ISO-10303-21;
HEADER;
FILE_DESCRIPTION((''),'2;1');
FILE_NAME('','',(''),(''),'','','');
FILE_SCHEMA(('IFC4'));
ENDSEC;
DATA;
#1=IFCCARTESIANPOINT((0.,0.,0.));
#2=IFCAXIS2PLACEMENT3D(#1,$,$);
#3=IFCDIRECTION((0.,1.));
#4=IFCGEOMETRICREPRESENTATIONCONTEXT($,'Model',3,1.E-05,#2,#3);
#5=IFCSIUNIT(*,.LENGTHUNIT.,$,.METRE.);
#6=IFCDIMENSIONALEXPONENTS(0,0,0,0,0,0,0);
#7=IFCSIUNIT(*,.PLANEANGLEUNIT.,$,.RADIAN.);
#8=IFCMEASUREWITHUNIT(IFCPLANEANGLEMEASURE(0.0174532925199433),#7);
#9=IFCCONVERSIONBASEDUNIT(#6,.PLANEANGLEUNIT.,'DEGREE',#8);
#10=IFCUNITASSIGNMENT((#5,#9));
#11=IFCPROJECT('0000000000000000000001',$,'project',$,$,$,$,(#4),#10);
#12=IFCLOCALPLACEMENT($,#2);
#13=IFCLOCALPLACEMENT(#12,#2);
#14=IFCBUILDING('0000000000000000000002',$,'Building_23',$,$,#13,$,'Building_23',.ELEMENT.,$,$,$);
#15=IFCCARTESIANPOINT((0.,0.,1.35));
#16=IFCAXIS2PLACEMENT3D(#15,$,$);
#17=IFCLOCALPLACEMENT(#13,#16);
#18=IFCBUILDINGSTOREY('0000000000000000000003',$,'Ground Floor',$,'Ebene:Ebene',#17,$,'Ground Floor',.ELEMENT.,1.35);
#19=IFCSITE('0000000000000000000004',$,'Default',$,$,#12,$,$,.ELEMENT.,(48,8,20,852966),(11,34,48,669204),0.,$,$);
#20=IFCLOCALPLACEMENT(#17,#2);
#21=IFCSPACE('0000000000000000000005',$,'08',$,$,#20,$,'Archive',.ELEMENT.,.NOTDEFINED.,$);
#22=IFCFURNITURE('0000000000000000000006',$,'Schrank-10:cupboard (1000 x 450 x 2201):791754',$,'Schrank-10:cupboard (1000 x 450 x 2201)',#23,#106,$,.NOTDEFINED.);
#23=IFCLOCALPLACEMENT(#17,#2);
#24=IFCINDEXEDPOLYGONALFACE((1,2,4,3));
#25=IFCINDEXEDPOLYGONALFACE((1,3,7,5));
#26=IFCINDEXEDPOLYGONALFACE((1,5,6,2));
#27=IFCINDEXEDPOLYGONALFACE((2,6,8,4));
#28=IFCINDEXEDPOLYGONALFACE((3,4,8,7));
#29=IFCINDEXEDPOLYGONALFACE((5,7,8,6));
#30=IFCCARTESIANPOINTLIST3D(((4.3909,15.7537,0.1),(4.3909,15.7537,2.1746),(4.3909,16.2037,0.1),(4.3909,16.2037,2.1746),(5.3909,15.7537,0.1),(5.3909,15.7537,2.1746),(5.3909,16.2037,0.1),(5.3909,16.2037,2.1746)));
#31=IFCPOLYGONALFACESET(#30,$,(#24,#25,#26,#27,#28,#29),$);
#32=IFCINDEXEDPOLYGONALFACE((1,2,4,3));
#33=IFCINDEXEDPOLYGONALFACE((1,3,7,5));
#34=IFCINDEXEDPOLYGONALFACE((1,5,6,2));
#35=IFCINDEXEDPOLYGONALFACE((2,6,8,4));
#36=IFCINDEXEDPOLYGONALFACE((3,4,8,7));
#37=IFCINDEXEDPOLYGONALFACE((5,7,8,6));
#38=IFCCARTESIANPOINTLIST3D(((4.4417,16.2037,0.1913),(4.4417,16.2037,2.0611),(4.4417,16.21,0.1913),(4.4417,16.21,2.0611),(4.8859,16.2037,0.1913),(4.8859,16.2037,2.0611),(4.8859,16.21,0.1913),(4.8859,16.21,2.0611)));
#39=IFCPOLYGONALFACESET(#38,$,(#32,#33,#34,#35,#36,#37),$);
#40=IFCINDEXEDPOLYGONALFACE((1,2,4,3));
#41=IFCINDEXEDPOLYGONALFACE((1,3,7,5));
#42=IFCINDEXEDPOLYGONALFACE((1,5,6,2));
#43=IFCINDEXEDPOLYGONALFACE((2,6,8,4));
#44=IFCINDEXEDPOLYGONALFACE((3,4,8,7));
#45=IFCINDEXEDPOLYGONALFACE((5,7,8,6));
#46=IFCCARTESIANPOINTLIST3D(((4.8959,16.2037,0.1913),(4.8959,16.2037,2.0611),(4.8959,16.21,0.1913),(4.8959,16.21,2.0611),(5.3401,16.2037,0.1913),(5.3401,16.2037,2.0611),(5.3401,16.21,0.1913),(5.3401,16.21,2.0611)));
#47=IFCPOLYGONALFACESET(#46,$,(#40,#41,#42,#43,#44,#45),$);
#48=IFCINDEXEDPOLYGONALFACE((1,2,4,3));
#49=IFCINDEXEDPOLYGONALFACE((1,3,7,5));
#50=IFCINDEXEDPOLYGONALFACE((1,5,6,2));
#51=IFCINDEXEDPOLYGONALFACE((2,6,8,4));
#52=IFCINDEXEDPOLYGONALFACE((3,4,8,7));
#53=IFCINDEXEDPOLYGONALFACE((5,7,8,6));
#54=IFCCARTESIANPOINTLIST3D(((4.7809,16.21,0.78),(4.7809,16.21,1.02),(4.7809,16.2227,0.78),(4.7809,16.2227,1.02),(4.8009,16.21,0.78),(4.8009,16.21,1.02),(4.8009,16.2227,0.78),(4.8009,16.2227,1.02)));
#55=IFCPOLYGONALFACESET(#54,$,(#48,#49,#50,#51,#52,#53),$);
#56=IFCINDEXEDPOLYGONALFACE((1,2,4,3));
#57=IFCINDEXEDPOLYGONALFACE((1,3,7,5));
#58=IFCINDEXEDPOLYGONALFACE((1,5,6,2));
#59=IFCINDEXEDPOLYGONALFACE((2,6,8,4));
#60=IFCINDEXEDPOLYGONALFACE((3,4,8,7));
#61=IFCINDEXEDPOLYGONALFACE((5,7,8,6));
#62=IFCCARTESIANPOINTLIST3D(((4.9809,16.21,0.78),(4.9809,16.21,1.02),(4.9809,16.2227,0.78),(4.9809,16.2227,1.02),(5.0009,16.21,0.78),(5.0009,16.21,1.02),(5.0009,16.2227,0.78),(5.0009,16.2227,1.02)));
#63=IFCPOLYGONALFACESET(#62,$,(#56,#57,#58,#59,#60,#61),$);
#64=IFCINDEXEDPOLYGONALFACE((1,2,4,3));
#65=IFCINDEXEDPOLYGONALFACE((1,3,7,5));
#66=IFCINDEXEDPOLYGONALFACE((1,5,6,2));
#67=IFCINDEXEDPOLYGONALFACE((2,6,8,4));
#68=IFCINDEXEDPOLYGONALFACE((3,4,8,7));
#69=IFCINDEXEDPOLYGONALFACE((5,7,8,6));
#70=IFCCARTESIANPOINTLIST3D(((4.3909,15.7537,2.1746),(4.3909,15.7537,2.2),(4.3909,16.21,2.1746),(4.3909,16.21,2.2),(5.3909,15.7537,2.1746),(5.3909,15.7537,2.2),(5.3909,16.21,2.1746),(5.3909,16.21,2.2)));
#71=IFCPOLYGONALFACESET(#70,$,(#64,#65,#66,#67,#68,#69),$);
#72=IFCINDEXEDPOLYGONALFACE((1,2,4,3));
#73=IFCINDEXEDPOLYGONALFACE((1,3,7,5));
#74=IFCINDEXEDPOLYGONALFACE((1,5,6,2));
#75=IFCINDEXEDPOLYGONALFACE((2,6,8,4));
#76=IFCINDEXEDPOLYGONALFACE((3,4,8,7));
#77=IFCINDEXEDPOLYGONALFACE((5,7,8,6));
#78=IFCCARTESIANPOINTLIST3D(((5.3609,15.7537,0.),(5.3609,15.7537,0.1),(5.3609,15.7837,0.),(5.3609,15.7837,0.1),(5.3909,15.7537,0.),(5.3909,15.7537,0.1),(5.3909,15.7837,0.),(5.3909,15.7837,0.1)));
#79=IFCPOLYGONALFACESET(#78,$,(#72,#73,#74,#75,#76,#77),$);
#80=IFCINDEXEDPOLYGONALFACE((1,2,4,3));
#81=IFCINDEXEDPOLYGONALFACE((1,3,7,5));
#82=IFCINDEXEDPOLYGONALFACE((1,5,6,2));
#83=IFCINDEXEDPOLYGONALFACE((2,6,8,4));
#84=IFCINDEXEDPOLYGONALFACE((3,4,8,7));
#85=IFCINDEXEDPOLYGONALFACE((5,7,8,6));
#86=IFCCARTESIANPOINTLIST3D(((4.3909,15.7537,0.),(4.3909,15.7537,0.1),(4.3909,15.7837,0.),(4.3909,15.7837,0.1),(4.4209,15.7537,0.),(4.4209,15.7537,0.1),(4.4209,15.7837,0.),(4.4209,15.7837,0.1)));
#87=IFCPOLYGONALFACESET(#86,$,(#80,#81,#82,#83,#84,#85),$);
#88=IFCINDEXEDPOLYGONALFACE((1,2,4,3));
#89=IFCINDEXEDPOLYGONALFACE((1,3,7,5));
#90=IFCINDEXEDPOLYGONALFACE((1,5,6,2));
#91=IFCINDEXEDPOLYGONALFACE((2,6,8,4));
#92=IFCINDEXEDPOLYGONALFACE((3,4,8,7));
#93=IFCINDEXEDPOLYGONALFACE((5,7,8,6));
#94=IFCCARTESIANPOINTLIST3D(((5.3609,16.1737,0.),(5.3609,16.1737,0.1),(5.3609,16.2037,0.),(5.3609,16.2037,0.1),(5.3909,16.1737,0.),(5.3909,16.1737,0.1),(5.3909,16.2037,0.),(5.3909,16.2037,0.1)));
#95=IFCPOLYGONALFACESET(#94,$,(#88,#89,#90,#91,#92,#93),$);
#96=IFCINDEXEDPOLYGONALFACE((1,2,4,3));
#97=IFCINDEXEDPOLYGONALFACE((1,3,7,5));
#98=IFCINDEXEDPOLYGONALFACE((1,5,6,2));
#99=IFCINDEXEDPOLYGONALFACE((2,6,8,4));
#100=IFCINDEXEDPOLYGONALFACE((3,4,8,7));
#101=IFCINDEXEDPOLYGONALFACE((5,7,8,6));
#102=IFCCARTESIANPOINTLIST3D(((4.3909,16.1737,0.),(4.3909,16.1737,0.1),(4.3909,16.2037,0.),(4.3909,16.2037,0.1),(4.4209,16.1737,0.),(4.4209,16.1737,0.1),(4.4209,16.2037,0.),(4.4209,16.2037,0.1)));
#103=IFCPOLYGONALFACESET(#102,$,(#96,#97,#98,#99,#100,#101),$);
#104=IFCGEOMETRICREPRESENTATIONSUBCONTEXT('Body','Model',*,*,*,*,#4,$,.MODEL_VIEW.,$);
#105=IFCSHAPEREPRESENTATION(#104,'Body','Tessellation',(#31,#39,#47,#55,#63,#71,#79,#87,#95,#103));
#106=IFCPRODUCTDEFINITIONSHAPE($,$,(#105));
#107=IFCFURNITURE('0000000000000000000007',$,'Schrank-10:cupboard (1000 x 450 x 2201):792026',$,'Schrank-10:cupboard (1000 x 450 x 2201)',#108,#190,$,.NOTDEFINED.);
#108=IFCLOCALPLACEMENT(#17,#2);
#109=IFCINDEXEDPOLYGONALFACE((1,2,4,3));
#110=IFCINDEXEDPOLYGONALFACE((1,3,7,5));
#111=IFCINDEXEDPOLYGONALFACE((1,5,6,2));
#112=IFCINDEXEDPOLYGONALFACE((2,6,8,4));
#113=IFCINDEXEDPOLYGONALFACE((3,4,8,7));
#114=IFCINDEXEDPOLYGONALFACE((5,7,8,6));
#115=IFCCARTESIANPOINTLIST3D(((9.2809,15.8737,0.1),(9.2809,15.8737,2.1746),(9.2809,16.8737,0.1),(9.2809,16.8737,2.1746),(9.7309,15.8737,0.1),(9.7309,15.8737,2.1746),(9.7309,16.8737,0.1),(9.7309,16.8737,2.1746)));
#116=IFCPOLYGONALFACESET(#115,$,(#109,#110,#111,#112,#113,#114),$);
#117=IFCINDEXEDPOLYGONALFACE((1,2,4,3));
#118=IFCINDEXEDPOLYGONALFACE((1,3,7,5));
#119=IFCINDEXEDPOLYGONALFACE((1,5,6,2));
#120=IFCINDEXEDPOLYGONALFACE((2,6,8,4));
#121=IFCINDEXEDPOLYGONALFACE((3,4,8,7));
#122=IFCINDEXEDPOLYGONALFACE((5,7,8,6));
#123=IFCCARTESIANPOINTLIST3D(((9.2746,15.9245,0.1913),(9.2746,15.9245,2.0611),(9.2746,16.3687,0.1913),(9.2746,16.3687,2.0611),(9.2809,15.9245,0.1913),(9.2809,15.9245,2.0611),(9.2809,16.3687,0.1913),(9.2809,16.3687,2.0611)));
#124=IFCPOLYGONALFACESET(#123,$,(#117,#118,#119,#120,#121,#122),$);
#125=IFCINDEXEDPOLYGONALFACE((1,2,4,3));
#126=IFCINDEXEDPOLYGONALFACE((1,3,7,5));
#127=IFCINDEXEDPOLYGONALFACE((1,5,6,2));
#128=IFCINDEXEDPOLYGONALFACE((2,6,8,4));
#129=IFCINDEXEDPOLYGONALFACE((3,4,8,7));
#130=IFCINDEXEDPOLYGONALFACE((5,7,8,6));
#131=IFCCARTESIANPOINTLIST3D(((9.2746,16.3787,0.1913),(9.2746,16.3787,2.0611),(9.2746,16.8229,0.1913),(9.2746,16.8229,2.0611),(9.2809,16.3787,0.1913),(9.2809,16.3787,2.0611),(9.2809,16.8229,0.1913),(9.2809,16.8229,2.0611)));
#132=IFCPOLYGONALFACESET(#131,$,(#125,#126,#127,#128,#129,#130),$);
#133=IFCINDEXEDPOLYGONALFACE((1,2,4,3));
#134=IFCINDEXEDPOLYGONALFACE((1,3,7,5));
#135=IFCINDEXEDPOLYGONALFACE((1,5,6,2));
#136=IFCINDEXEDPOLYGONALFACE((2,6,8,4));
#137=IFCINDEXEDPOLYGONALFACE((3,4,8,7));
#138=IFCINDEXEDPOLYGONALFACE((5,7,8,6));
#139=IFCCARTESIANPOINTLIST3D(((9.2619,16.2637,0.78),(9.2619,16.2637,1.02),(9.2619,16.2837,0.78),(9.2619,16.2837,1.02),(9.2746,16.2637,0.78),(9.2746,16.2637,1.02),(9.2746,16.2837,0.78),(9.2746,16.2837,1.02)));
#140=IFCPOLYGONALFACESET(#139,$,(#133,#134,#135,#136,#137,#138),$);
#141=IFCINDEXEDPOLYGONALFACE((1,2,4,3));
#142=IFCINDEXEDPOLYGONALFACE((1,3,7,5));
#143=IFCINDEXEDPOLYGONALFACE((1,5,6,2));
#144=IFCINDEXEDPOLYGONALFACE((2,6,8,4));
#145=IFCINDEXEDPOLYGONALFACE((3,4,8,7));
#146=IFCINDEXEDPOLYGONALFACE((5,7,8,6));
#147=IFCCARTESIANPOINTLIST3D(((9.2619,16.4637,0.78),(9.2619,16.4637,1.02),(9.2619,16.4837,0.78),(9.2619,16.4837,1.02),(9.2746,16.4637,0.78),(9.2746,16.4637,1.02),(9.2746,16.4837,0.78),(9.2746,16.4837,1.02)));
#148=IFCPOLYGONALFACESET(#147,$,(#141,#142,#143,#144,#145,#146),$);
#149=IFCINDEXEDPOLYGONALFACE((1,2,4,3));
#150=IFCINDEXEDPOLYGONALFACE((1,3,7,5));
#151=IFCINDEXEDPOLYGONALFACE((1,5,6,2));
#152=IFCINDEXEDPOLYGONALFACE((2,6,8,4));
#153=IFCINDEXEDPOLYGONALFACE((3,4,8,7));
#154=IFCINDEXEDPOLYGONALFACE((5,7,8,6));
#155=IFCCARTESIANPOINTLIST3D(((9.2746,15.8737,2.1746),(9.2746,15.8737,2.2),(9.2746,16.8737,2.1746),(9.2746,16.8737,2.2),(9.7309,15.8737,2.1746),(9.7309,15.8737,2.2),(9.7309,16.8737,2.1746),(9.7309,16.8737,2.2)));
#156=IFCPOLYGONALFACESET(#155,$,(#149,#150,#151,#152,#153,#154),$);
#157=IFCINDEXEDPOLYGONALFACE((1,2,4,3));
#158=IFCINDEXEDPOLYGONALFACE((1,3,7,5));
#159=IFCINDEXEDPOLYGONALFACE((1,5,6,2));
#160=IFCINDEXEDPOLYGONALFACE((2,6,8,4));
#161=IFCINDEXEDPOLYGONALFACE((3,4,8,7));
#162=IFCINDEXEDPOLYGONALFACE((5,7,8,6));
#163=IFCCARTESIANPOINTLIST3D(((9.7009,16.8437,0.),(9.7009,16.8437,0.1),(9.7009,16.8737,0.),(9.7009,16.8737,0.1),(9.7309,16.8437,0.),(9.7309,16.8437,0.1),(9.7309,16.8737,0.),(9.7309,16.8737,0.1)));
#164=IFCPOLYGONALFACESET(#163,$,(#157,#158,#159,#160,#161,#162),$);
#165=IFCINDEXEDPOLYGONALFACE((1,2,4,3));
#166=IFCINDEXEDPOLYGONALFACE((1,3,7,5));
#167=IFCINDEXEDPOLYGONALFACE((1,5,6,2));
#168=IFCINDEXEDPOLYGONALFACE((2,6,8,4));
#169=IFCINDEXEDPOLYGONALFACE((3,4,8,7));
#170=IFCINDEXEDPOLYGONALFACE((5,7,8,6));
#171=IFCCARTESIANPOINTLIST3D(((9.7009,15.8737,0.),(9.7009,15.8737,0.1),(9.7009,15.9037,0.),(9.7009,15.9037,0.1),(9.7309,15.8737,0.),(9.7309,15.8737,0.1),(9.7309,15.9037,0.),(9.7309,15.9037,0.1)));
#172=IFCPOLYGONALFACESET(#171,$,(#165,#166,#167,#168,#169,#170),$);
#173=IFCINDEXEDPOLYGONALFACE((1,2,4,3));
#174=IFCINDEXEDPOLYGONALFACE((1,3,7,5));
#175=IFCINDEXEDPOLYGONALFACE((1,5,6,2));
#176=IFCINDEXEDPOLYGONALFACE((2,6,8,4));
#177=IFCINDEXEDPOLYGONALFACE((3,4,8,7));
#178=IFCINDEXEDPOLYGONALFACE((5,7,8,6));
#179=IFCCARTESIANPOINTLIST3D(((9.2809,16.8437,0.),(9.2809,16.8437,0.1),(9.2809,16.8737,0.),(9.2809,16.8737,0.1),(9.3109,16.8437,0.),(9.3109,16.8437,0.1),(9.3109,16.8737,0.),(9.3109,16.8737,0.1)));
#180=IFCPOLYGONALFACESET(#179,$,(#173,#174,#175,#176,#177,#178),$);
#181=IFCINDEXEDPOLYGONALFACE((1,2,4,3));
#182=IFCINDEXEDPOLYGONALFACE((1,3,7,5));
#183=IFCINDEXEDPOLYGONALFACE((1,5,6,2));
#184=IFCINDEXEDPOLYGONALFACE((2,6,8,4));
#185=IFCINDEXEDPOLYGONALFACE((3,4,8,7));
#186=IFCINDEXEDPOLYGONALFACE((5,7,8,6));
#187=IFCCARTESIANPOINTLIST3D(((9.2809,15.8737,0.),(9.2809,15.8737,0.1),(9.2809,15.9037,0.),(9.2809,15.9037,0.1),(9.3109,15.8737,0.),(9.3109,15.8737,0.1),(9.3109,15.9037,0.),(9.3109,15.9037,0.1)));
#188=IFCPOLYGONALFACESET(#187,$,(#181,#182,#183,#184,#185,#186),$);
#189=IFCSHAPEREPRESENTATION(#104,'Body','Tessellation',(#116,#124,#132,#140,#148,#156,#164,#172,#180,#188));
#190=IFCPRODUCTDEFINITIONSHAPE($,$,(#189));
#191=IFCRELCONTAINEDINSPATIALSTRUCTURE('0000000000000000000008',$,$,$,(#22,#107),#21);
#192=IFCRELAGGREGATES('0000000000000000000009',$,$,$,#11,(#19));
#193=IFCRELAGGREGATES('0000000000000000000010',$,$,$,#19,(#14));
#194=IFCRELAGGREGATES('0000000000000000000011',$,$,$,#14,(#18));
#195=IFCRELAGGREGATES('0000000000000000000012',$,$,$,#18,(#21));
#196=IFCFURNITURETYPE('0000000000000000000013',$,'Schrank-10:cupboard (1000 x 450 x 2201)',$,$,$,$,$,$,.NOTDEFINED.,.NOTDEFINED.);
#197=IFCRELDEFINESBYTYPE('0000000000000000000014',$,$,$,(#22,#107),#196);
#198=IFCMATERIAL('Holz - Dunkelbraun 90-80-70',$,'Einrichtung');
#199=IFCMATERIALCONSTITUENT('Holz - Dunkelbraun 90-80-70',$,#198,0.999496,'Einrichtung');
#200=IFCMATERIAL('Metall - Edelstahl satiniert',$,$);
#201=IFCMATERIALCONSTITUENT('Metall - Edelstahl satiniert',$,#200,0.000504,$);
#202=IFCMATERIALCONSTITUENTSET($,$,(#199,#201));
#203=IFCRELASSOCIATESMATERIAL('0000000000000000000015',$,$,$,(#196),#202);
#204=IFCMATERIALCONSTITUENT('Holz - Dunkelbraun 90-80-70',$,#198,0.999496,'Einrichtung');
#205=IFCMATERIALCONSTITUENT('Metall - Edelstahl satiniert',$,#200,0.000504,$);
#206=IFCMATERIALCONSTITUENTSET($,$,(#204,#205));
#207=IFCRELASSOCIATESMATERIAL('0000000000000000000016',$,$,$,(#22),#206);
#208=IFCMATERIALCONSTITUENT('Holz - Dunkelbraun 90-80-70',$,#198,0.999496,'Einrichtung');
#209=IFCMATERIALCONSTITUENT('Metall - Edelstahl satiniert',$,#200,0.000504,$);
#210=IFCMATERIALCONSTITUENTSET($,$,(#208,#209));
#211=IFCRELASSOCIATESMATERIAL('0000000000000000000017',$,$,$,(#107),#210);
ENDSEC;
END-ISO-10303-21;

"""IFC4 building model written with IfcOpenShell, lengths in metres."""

from ifc_helpers import new_model, entity, si_unit, converted_unit, direction, frame, origin, place, context, subcontext, project, spatial, indexed_curve, outline, extrude, source, transform, mapped, material, constituent, constituent_set, type_object, type_shapes, element, save


model = new_model("IFC4")

# Units and contexts
model_context = context("Model", 3, precision=1e-05, world=origin(), true_north=direction((0.0, 1.0)))
body_context = subcontext(model_context, "Body", "Model", "MODEL_VIEW")
ifc_project = project(units=[si_unit("LENGTHUNIT", "METRE"), converted_unit("PLANEANGLEUNIT", "DEGREE", entity("IfcPlaneAngleMeasure", 0.0174532925199433), si_unit("PLANEANGLEUNIT", "RADIAN"), dimensions=[0, 0, 0, 0, 0, 0, 0])], contexts=[model_context])

# Site, building, storey
site_placement = place(None, origin())
site = spatial("IfcSite", under=ifc_project, at=site_placement, Name="Default", CompositionType="ELEMENT", RefLatitude=(48, 8, 20, 852966), RefLongitude=(11, 34, 48, 669204), RefElevation=0.0)
building_placement = place(site_placement, origin())
building = spatial("IfcBuilding", under=site, at=building_placement, Name="Building_23", LongName="Building_23", CompositionType="ELEMENT")
storey_placement = place(building_placement, frame((0.0, 0.0, 1.35)))
storey = spatial("IfcBuildingStorey", under=building, at=storey_placement, Name="Ground Floor", ObjectType="Ebene:Ebene", LongName="Ground Floor", CompositionType="ELEMENT", Elevation=1.35)

# Shared definitions
space_placement = place(storey_placement, origin())
space = spatial("IfcSpace", under=storey, at=space_placement, Name="08", LongName="Archive", CompositionType="ELEMENT", PredefinedType="NOTDEFINED")

# Furniture
ifc_material_1 = material(Name="Holz - Dunkelbraun 90-80-70", Category="Einrichtung")
ifc_constituent_1 = constituent(ifc_material_1, Name="Holz - Dunkelbraun 90-80-70", Category="Einrichtung", fraction=0.999496)
ifc_material_2 = material(Name="Metall - Edelstahl satiniert")
ifc_constituent_2 = constituent(ifc_material_2, Name="Metall - Edelstahl satiniert", fraction=0.000504)
ifc_constituent_set_1 = constituent_set(constituents=[ifc_constituent_1, ifc_constituent_2])
ifc_constituent_3 = constituent(ifc_material_1, Name="Holz - Dunkelbraun 90-80-70", Category="Einrichtung", fraction=0.999496)
ifc_constituent_4 = constituent(ifc_material_2, Name="Metall - Edelstahl satiniert", fraction=0.000504)
ifc_constituent_set_2 = constituent_set(constituents=[ifc_constituent_3, ifc_constituent_4])
furniture_type = type_object("IfcFurnitureType", Name="Schrank-10:cupboard (1000 x 450 x 2201)", AssemblyPlace="NOTDEFINED", PredefinedType="NOTDEFINED", material=ifc_constituent_set_2)
shared_shape_1 = source(origin(), body_context, "Body", "SweptSolid", [
    extrude(outline(indexed_curve([(-0.225, -0.5), (0.225, -0.5), (0.225, 0.5), (-0.225, 0.5), (-0.225, -0.5)], self_intersect=False)), frame((-0.2692, -0.3632, 0.1), z_axis=(0.0, 0.0, 1.0), x_axis=(0.0, 1.0, 0.0)), (0.0, 0.0, 1.0), 2.0746),
    extrude(outline(indexed_curve([(-0.0032, -0.2221), (0.0032, -0.2221), (0.0032, 0.2221), (-0.0032, 0.2221), (-0.0032, -0.2221)], self_intersect=False)), frame((-0.0421, -0.5913, 0.1913), z_axis=(0.0, 0.0, 1.0), x_axis=(0.0, 1.0, 0.0)), (0.0, 0.0, 1.0), 1.8698),
    extrude(outline(indexed_curve([(-0.0032, -0.2221), (0.0032, -0.2221), (0.0032, 0.2221), (-0.0032, 0.2221), (-0.0032, -0.2221)], self_intersect=False)), frame((-0.4963, -0.5913, 0.1913), z_axis=(0.0, 0.0, 1.0), x_axis=(0.0, 1.0, 0.0)), (0.0, 0.0, 1.0), 1.8698),
    extrude(outline(indexed_curve([(-0.0063, -0.01), (0.0063, -0.01), (0.0063, 0.01), (-0.0063, 0.01), (-0.0063, -0.01)], self_intersect=False)), frame((-0.1692, -0.6009, 0.78), z_axis=(0.0, 0.0, 1.0), x_axis=(0.0, 1.0, 0.0)), (0.0, 0.0, 1.0), 0.24),
    extrude(outline(indexed_curve([(-0.0063, -0.01), (0.0063, -0.01), (0.0063, 0.01), (-0.0063, 0.01), (-0.0063, -0.01)], self_intersect=False)), frame((-0.3692, -0.6009, 0.78), z_axis=(0.0, 0.0, 1.0), x_axis=(0.0, 1.0, 0.0)), (0.0, 0.0, 1.0), 0.24),
    extrude(outline(indexed_curve([(-0.5, -0.2282), (0.5, -0.2282), (0.5, 0.2282), (-0.5, 0.2282), (-0.5, -0.2282)], self_intersect=False)), frame((-0.2692, -0.3663, 2.1746), z_axis=(0.0, 0.0, 1.0), x_axis=(-1.0, 0.0, 0.0)), (0.0, 0.0, 1.0), 0.0254),
    extrude(outline(indexed_curve([(-0.015, -0.015), (0.015, -0.015), (0.015, 0.015), (-0.015, 0.015), (-0.015, -0.015)], self_intersect=False)), frame((-0.7542, -0.1532, 0.0), z_axis=(0.0, 0.0, 1.0), x_axis=(-1.0, 0.0, 0.0)), (0.0, 0.0, 1.0), 0.1),
    extrude(outline(indexed_curve([(-0.015, -0.015), (0.015, -0.015), (0.015, 0.015), (-0.015, 0.015), (-0.015, -0.015)], self_intersect=False)), frame((0.2158, -0.1532, 0.0), z_axis=(0.0, 0.0, 1.0), x_axis=(0.0, -1.0, 0.0)), (0.0, 0.0, 1.0), 0.1),
    extrude(outline(indexed_curve([(-0.015, -0.015), (0.015, -0.015), (0.015, 0.015), (-0.015, 0.015), (-0.015, -0.015)], self_intersect=False)), frame((-0.7542, -0.5732, 0.0), z_axis=(0.0, 0.0, 1.0), x_axis=(0.0, 1.0, 0.0)), (0.0, 0.0, 1.0), 0.1),
    extrude(outline(indexed_curve([(-0.015, -0.015), (0.015, -0.015), (0.015, 0.015), (-0.015, 0.015), (-0.015, -0.015)], self_intersect=False)), frame((0.2158, -0.5732, 0.0)), (0.0, 0.0, 1.0), 0.1),
])
type_shapes(furniture_type, [shared_shape_1])
furniture_1_placement = place(space_placement, frame((4.6217, 15.6155, 0.0), z_axis=(0.0, 0.0, 1.0), x_axis=(-1.0, 0.0, 0.0)))
element("IfcFurniture", 1, at=furniture_1_placement, inside=space, type_object=furniture_type, material=ifc_constituent_set_1, Name="Schrank-10:cupboard (1000 x 450 x 2201):791754", ObjectType="Schrank-10:cupboard (1000 x 450 x 2201)", PredefinedType="NOTDEFINED", context=body_context, shape_type="MappedRepresentation", body=[
    mapped(shared_shape_1, transform((0.0, 0.0, 0.0), scale=1.0)),
])
ifc_constituent_5 = constituent(ifc_material_1, Name="Holz - Dunkelbraun 90-80-70", Category="Einrichtung", fraction=0.999496)
ifc_constituent_6 = constituent(ifc_material_2, Name="Metall - Edelstahl satiniert", fraction=0.000504)
ifc_constituent_set_3 = constituent_set(constituents=[ifc_constituent_5, ifc_constituent_6])
furniture_2_placement = place(space_placement, frame((9.8691, 16.1045, 0.0), z_axis=(0.0, 0.0, 1.0), x_axis=(0.0, -1.0, 0.0)))
element("IfcFurniture", 2, at=furniture_2_placement, inside=space, type_object=furniture_type, material=ifc_constituent_set_3, Name="Schrank-10:cupboard (1000 x 450 x 2201):792026", ObjectType="Schrank-10:cupboard (1000 x 450 x 2201)", PredefinedType="NOTDEFINED", context=body_context, shape_type="MappedRepresentation", body=[
    mapped(shared_shape_1, transform((0.0, 0.0, 0.0), scale=1.0)),
])

save(model, "model.ifc")
